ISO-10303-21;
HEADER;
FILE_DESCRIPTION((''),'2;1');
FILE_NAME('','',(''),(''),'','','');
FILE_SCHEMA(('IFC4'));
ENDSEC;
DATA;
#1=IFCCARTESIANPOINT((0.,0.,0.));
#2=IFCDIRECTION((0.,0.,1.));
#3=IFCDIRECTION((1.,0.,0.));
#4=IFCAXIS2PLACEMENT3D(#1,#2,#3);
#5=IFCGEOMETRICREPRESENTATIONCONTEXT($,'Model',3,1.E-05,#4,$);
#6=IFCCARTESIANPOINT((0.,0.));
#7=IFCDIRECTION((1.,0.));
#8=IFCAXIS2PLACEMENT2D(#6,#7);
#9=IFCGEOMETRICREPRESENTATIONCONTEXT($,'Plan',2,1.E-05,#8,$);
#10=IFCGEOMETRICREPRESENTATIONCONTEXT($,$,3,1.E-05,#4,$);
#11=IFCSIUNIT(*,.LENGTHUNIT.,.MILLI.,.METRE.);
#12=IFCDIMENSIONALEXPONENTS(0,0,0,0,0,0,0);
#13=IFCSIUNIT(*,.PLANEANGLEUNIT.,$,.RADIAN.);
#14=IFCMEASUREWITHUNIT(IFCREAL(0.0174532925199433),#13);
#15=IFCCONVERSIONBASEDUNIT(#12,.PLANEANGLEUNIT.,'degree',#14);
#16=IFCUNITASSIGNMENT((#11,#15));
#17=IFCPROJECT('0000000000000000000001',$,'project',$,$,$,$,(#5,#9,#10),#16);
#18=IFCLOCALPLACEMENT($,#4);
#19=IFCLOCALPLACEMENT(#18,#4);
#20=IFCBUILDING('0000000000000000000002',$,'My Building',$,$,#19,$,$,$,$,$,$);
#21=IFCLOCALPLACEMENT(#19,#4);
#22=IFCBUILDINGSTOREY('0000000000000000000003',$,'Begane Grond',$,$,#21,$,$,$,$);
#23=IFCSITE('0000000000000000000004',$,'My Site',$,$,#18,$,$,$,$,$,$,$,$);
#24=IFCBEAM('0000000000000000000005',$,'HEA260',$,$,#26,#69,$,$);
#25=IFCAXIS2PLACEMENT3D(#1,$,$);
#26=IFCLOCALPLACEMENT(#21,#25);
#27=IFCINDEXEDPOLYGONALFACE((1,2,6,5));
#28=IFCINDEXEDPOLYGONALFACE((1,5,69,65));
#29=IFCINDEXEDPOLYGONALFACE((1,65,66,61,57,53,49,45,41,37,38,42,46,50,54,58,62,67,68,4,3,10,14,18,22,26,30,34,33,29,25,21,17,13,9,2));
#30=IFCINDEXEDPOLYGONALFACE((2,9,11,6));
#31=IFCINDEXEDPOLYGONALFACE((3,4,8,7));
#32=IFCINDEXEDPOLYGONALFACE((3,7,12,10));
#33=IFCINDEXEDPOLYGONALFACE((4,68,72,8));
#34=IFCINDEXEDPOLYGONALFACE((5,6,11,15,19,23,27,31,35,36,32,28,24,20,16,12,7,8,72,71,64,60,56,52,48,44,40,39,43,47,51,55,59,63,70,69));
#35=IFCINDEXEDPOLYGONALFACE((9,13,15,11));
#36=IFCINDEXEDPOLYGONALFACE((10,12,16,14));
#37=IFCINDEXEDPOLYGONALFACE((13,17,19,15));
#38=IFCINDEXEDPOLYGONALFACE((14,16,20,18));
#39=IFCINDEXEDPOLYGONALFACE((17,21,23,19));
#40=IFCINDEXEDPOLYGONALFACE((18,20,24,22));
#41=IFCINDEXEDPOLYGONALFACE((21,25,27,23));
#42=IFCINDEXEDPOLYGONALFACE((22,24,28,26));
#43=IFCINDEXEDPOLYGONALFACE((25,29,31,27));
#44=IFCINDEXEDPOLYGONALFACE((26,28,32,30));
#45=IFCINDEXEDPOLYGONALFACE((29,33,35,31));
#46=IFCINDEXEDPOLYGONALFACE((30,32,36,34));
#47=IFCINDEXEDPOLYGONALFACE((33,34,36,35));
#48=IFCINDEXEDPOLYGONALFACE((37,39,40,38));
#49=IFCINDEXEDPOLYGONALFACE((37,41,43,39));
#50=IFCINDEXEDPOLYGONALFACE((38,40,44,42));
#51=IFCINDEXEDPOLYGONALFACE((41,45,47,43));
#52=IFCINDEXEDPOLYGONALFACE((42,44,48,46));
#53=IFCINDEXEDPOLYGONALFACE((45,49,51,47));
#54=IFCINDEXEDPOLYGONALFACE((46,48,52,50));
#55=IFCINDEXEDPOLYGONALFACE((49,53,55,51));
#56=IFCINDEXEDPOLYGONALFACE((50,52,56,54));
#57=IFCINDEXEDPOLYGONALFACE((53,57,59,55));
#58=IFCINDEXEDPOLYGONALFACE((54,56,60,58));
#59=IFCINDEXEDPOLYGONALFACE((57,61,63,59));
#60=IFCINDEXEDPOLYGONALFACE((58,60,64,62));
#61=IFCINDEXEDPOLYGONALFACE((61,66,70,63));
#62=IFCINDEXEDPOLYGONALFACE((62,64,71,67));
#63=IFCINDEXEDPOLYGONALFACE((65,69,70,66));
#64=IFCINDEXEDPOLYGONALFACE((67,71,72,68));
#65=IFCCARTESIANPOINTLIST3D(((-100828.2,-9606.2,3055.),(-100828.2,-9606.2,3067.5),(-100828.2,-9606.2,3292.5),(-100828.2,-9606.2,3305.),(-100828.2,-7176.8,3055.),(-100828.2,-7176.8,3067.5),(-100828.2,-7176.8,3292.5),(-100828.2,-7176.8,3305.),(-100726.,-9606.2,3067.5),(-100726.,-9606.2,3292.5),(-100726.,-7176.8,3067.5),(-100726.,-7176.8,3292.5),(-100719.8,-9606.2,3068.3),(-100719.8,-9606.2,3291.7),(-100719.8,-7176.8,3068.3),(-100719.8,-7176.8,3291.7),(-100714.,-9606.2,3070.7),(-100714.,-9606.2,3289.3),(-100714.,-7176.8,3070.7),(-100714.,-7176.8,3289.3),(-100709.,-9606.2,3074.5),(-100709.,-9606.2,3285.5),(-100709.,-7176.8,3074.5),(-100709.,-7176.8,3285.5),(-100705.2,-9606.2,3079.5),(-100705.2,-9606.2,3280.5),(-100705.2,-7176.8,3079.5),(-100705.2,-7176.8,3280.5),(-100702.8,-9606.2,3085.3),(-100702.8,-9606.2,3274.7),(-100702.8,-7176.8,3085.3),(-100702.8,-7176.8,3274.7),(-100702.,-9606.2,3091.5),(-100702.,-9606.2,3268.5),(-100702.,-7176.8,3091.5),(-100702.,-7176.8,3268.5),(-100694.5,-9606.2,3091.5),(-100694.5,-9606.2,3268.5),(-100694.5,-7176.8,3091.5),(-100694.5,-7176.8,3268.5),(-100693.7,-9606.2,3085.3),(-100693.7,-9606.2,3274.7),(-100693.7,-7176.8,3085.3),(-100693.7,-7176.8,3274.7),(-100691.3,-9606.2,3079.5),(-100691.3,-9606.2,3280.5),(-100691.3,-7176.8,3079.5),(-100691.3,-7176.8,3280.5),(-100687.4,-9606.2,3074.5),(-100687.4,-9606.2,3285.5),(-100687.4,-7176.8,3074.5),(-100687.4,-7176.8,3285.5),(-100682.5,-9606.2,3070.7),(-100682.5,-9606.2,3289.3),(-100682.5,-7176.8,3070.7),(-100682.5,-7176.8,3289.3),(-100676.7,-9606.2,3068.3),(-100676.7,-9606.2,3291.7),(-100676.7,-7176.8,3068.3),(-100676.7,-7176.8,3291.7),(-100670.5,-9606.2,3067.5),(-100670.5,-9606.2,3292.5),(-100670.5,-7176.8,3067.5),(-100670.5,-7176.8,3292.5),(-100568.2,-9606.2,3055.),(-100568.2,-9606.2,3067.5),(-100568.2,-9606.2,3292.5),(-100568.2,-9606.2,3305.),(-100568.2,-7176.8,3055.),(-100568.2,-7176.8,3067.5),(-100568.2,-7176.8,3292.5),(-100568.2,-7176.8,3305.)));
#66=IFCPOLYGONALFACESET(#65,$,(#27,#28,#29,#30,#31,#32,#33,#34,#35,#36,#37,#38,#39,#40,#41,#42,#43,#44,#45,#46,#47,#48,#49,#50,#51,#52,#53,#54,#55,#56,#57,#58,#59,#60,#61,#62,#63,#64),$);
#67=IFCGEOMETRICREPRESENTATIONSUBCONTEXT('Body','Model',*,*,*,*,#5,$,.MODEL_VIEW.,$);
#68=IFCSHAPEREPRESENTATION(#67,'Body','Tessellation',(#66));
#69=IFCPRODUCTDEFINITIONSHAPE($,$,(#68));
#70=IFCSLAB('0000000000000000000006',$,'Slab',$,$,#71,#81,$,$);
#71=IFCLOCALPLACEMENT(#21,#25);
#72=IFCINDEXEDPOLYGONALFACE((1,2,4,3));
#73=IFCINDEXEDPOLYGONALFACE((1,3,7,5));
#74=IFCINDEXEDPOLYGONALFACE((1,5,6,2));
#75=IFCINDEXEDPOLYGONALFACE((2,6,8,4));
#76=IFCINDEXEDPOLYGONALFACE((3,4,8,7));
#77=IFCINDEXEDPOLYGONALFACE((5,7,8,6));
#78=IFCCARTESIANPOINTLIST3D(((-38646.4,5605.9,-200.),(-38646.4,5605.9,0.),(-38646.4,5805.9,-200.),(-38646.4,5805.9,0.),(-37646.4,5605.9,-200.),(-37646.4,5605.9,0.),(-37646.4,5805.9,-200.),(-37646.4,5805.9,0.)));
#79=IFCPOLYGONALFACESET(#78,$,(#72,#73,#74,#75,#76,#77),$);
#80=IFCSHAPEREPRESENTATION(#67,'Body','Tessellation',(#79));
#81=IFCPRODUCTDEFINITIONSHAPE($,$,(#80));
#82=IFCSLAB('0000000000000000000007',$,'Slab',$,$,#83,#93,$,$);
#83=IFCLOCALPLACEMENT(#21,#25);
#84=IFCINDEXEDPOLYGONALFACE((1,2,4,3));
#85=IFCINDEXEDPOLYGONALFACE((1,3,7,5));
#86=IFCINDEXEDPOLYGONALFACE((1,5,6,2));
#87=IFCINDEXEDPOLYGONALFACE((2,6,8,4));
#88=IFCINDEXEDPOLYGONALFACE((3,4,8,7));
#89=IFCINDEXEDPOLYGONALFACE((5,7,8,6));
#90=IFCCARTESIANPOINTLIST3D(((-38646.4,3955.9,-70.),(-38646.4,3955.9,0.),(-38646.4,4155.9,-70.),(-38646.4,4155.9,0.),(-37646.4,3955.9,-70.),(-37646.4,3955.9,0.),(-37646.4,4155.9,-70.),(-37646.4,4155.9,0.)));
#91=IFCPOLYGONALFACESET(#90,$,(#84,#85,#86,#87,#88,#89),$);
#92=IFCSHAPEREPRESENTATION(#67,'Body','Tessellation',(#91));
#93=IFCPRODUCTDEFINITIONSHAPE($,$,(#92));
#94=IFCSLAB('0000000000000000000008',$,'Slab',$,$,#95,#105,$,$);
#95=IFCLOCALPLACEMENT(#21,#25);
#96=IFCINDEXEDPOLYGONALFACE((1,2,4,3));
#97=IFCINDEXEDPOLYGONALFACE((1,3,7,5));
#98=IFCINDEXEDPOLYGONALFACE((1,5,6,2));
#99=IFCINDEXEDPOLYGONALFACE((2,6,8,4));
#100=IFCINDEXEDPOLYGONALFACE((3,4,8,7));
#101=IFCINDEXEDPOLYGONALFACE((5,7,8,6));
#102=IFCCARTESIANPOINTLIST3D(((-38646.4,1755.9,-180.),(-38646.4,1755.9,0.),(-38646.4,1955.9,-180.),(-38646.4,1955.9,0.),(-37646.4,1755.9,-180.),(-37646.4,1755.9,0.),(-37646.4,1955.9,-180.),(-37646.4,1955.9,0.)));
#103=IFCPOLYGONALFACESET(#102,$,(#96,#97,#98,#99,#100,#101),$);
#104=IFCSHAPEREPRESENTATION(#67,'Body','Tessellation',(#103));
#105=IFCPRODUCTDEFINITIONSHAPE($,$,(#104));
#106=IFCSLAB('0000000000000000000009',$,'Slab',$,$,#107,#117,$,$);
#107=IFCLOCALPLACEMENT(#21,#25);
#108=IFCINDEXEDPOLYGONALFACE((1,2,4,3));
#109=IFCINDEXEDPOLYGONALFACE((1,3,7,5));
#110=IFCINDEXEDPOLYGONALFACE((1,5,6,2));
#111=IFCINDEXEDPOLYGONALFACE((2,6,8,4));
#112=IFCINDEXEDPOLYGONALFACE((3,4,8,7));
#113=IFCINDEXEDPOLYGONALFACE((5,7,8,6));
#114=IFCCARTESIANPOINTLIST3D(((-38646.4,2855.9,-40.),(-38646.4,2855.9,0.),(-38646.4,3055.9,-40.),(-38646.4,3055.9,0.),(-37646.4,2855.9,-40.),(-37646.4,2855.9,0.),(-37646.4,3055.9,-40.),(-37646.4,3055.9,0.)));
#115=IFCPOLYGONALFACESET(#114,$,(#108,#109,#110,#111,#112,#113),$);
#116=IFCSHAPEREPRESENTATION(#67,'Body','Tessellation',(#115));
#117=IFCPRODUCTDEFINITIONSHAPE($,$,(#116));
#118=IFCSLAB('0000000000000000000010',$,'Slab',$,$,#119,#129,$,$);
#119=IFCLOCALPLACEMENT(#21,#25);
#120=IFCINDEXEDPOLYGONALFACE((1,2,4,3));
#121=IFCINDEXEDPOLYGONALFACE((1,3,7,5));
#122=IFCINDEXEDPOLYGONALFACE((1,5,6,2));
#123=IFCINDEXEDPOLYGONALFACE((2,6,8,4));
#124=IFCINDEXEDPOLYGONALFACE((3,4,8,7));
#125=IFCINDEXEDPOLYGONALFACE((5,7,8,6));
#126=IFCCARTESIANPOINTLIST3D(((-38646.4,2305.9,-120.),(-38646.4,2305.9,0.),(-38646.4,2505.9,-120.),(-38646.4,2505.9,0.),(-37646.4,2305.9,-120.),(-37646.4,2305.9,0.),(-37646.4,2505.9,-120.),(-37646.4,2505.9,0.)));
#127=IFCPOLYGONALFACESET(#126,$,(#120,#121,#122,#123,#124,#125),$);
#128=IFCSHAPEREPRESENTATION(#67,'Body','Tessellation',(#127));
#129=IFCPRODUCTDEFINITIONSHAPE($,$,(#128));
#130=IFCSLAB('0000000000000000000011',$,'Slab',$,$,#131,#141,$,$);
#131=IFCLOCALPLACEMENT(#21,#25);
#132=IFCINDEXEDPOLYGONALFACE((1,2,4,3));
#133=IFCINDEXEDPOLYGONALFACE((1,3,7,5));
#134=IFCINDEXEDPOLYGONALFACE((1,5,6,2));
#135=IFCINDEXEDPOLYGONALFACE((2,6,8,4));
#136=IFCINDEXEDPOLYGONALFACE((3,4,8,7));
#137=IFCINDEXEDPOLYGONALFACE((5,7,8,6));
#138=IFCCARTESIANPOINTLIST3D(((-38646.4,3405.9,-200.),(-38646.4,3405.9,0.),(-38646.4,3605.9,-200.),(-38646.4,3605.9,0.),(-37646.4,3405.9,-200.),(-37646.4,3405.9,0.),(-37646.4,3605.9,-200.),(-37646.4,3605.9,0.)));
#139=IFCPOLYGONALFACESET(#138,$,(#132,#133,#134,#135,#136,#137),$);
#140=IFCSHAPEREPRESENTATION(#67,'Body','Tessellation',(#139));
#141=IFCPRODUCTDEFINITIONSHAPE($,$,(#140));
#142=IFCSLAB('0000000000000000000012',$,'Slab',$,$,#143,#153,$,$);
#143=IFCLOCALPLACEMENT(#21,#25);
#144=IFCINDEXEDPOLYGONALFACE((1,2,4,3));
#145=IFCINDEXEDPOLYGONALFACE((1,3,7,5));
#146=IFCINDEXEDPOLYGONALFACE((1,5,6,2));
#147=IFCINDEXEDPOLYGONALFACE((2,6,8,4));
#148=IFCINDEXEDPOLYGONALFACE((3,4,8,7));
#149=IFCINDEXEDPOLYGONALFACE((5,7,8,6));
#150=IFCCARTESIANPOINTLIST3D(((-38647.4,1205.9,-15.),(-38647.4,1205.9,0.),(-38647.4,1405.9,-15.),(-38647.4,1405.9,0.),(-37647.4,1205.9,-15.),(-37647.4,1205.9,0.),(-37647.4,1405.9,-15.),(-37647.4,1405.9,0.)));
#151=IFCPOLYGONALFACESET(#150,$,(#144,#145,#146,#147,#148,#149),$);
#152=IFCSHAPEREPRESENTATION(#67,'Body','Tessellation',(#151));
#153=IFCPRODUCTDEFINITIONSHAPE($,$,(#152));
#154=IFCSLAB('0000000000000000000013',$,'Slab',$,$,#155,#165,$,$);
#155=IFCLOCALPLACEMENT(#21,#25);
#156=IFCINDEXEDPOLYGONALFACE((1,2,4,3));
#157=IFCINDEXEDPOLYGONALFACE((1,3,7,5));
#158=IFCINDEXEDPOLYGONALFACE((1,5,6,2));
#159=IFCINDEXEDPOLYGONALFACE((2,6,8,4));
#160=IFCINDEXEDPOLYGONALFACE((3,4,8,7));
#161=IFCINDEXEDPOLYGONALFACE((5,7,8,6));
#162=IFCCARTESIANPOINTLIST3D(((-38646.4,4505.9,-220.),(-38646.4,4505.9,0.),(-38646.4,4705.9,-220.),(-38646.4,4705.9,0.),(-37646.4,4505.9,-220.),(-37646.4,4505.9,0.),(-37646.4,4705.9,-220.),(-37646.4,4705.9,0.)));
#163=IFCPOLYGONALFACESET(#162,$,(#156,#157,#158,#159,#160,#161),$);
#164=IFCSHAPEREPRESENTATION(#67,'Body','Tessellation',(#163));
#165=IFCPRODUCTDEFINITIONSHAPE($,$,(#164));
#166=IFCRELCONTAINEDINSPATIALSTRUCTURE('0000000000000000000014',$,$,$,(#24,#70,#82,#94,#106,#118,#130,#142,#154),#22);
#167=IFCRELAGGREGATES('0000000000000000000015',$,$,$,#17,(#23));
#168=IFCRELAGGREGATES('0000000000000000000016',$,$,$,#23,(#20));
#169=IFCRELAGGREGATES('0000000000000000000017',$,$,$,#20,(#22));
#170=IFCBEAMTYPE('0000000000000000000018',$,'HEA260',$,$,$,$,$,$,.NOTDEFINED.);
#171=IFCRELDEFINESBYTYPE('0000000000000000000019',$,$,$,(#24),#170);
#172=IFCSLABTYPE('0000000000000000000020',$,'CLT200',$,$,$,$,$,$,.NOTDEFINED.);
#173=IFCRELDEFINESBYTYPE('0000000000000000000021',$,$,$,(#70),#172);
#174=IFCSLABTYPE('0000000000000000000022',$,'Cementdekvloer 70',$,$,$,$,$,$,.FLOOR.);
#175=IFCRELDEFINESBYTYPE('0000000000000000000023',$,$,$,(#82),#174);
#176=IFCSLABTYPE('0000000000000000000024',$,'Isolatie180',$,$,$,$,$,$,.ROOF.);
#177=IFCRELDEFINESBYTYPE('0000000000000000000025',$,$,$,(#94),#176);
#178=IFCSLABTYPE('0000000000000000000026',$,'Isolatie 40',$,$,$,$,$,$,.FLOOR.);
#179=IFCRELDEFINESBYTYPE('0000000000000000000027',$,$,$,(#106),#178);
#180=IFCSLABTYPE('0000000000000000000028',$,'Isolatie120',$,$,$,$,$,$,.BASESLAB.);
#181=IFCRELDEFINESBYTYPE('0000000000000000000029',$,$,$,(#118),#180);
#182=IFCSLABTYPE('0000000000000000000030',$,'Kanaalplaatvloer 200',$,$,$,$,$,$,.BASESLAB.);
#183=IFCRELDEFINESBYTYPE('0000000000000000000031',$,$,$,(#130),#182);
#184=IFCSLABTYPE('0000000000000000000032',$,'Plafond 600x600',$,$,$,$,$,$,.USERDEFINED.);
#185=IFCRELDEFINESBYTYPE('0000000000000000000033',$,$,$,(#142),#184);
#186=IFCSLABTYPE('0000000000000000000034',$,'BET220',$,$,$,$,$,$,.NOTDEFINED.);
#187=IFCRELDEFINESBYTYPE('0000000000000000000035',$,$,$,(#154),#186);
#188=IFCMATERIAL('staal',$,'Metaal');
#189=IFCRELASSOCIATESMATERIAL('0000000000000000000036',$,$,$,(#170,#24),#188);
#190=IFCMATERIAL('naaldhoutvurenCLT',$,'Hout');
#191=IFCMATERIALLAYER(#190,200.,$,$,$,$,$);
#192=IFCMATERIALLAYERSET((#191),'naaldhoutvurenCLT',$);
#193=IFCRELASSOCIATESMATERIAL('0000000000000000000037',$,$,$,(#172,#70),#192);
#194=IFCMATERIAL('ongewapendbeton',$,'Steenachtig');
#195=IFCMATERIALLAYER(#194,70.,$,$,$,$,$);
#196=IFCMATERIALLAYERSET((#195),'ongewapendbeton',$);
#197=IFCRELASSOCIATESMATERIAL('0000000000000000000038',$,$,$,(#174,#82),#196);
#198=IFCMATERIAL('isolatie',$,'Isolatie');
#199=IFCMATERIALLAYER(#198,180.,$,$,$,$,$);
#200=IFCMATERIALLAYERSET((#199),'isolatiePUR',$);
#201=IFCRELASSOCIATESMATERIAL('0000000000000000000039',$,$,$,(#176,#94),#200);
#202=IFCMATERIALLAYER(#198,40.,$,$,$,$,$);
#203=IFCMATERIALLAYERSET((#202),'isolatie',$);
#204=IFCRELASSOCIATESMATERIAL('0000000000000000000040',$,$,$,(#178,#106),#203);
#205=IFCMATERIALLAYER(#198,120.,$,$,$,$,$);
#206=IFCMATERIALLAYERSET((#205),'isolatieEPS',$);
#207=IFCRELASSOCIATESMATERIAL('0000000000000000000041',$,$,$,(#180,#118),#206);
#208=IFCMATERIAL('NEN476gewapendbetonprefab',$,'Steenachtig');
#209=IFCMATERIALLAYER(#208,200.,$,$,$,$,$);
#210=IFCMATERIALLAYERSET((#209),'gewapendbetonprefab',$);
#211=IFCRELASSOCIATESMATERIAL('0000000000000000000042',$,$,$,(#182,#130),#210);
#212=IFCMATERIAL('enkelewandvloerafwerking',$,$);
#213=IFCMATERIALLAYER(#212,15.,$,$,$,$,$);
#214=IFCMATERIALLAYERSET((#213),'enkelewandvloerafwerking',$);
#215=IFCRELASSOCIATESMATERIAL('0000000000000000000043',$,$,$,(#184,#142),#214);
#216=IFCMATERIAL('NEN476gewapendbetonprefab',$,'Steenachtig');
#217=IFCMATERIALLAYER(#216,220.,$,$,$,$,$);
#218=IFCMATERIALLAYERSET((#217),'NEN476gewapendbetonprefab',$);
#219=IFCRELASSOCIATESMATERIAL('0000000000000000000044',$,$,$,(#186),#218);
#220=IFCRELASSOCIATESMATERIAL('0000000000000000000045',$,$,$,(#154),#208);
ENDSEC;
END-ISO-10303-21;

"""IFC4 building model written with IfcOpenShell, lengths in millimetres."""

from ifc_helpers import new_model, entity, si_unit, converted_unit, frame, origin_with_axes, origin_2d_with_axis, place, context, subcontext, project, spatial, line, indexed_curve, i_section, outline, extrude, material, layer, layer_set, layer_usage, material_profile, profile_set, profile_usage, type_object, element, save


model = new_model("IFC4")

# Units and contexts
model_context = context("Model", 3, precision=1e-05, world=origin_with_axes())
plan_context = context("Plan", 2, precision=1e-05, world=origin_2d_with_axis())
context_of_model = context(None, 3, precision=1e-05, world=origin_with_axes())
body_context = subcontext(model_context, "Body", "Model", "MODEL_VIEW")
ifc_project = project(units=[si_unit("LENGTHUNIT", "METRE", prefix="MILLI"), converted_unit("PLANEANGLEUNIT", "degree", entity("IfcReal", 0.0174532925199433), si_unit("PLANEANGLEUNIT", "RADIAN"), dimensions=[0, 0, 0, 0, 0, 0, 0])], contexts=[model_context, plan_context, context_of_model])

# Site, building, storey
site_placement = place(None, frame((0.0, 0.0, 0.0), z_axis=(0.0, 0.0, 1.0), x_axis=(1.0, 0.0, 0.0)))
site = spatial("IfcSite", under=ifc_project, at=site_placement, Name="My Site")
building_placement = place(site_placement, origin_with_axes())
building = spatial("IfcBuilding", under=site, at=building_placement, Name="My Building")
storey_placement = place(building_placement, origin_with_axes())
storey = spatial("IfcBuildingStorey", under=building, at=storey_placement, Name="Begane Grond")

# Beam
ifc_material_1 = material(Name="staal", Category="Metaal")
ifc_material_profile = material_profile(ifc_material_1, i_section(OverallWidth=260.0, OverallDepth=250.0, WebThickness=7.5, FlangeThickness=12.5, FilletRadius=24.0))
ifc_profile_set = profile_set([ifc_material_profile], Name="HEA260")
ifc_profile_usage = profile_usage(ifc_profile_set, cardinal=5)
beam_type = type_object("IfcBeamType", Name="HEA260", PredefinedType="NOTDEFINED", material=ifc_profile_set)
beam_placement = place(storey_placement, frame((-100698.2, -9606.2, 3180.0), z_axis=(0.0, 1.0, 0.0), x_axis=(-1.0, 0.0, 0.0)))
element("IfcBeam", 1, at=beam_placement, inside=storey, type_object=beam_type, material=ifc_profile_usage, Name="HEA260", context=body_context, shape_type="SweptSolid", body=[
    extrude(i_section(OverallWidth=260.0, OverallDepth=250.0, WebThickness=7.5, FlangeThickness=12.5, FilletRadius=24.0), origin_with_axes(), (0.0, 0.0, 1.0), 2429.4),
])

# Slabs
ifc_material_2 = material(Name="naaldhoutvurenCLT", Category="Hout")
ifc_layer_1 = layer(ifc_material_2, 200.0)
ifc_layer_set_1 = layer_set([ifc_layer_1], Name="naaldhoutvurenCLT")
ifc_layer_usage_1 = layer_usage(ifc_layer_set_1, "AXIS3", "POSITIVE", 0.0)
slab_type_1 = type_object("IfcSlabType", Name="CLT200", PredefinedType="NOTDEFINED", material=ifc_layer_set_1)
slab_1_placement = place(storey_placement, frame((-38646.4, 5605.9, -200.0), z_axis=(0.0, 0.0, 1.0), x_axis=(1.0, 0.0, 0.0)))
element("IfcSlab", 2, at=slab_1_placement, inside=storey, type_object=slab_type_1, material=ifc_layer_usage_1, Name="Slab", context=body_context, shape_type="SweptSolid", body=[
    extrude(outline(indexed_curve([(1000.0, 200.0), (1000.0, 0.0), (0.0, 0.0), (0.0, 200.0)], segments=[line(3, 2), line(2, 1), line(1, 4), line(4, 3)], self_intersect=False)), None, (0.0, 0.0, 1.0), 200.0),
])
ifc_material_3 = material(Name="ongewapendbeton", Category="Steenachtig")
ifc_layer_2 = layer(ifc_material_3, 70.0)
ifc_layer_set_2 = layer_set([ifc_layer_2], Name="ongewapendbeton")
ifc_layer_usage_2 = layer_usage(ifc_layer_set_2, "AXIS3", "POSITIVE", 0.0)
slab_type_2 = type_object("IfcSlabType", Name="Cementdekvloer 70", PredefinedType="FLOOR", material=ifc_layer_set_2)
slab_2_placement = place(storey_placement, frame((-38646.4, 3955.9, -70.0), z_axis=(0.0, 0.0, 1.0), x_axis=(1.0, 0.0, 0.0)))
element("IfcSlab", 3, at=slab_2_placement, inside=storey, type_object=slab_type_2, material=ifc_layer_usage_2, Name="Slab", context=body_context, shape_type="SweptSolid", body=[
    extrude(outline(indexed_curve([(1000.0, 200.0), (1000.0, 0.0), (0.0, 0.0), (0.0, 200.0)], segments=[line(4, 1), line(1, 2), line(2, 3), line(3, 4)], self_intersect=False)), None, (0.0, 0.0, 1.0), 70.0),
])
ifc_material_4 = material(Name="isolatie", Category="Isolatie")
ifc_layer_3 = layer(ifc_material_4, 180.0)
ifc_layer_set_3 = layer_set([ifc_layer_3], Name="isolatiePUR")
ifc_layer_usage_3 = layer_usage(ifc_layer_set_3, "AXIS3", "POSITIVE", 0.0)
slab_type_3 = type_object("IfcSlabType", Name="Isolatie180", PredefinedType="ROOF", material=ifc_layer_set_3)
slab_3_placement = place(storey_placement, frame((-38646.4, 1755.9, -180.0), z_axis=(0.0, 0.0, 1.0), x_axis=(1.0, 0.0, 0.0)))
element("IfcSlab", 4, at=slab_3_placement, inside=storey, type_object=slab_type_3, material=ifc_layer_usage_3, Name="Slab", context=body_context, shape_type="SweptSolid", body=[
    extrude(outline(indexed_curve([(1000.0, 200.0), (1000.0, 0.0), (0.0, 0.0), (0.0, 200.0)], segments=[line(4, 1), line(1, 2), line(2, 3), line(3, 4)], self_intersect=False)), None, (0.0, 0.0, 1.0), 180.0),
])
ifc_layer_4 = layer(ifc_material_4, 40.0)
ifc_layer_set_4 = layer_set([ifc_layer_4], Name="isolatie")
ifc_layer_usage_4 = layer_usage(ifc_layer_set_4, "AXIS3", "POSITIVE", 0.0)
slab_type_4 = type_object("IfcSlabType", Name="Isolatie 40", PredefinedType="FLOOR", material=ifc_layer_set_4)
slab_4_placement = place(storey_placement, frame((-38646.4, 2855.9, -40.0), z_axis=(0.0, 0.0, 1.0), x_axis=(1.0, 0.0, 0.0)))
element("IfcSlab", 5, at=slab_4_placement, inside=storey, type_object=slab_type_4, material=ifc_layer_usage_4, Name="Slab", context=body_context, shape_type="SweptSolid", body=[
    extrude(outline(indexed_curve([(1000.0, 200.0), (1000.0, 0.0), (0.0, 0.0), (0.0, 200.0)], segments=[line(3, 2), line(2, 1), line(1, 4), line(4, 3)], self_intersect=False)), None, (0.0, 0.0, 1.0), 40.0),
])
ifc_layer_5 = layer(ifc_material_4, 120.0)
ifc_layer_set_5 = layer_set([ifc_layer_5], Name="isolatieEPS")
ifc_layer_usage_5 = layer_usage(ifc_layer_set_5, "AXIS3", "POSITIVE", 0.0)
slab_type_5 = type_object("IfcSlabType", Name="Isolatie120", PredefinedType="BASESLAB", material=ifc_layer_set_5)
slab_5_placement = place(storey_placement, frame((-38646.4, 2305.9, -120.0), z_axis=(0.0, 0.0, 1.0), x_axis=(1.0, 0.0, 0.0)))
element("IfcSlab", 6, at=slab_5_placement, inside=storey, type_object=slab_type_5, material=ifc_layer_usage_5, Name="Slab", context=body_context, shape_type="SweptSolid", body=[
    extrude(outline(indexed_curve([(1000.0, 200.0), (1000.0, 0.0), (0.0, 0.0), (0.0, 200.0)], segments=[line(3, 2), line(2, 1), line(1, 4), line(4, 3)], self_intersect=False)), None, (0.0, 0.0, 1.0), 120.0),
])
ifc_material_5 = material(Name="NEN476gewapendbetonprefab", Category="Steenachtig")
ifc_layer_6 = layer(ifc_material_5, 200.0)
ifc_layer_set_6 = layer_set([ifc_layer_6], Name="gewapendbetonprefab")
ifc_layer_usage_6 = layer_usage(ifc_layer_set_6, "AXIS3", "POSITIVE", 0.0)
slab_type_6 = type_object("IfcSlabType", Name="Kanaalplaatvloer 200", PredefinedType="BASESLAB", material=ifc_layer_set_6)
slab_6_placement = place(storey_placement, frame((-38646.4, 3405.9, -200.0), z_axis=(0.0, 0.0, 1.0), x_axis=(1.0, 0.0, 0.0)))
element("IfcSlab", 7, at=slab_6_placement, inside=storey, type_object=slab_type_6, material=ifc_layer_usage_6, Name="Slab", context=body_context, shape_type="SweptSolid", body=[
    extrude(outline(indexed_curve([(1000.0, 200.0), (1000.0, 0.0), (0.0, 0.0), (0.0, 200.0)], segments=[line(4, 1), line(1, 2), line(2, 3), line(3, 4)], self_intersect=False)), None, (0.0, 0.0, 1.0), 200.0),
])
ifc_material_6 = material(Name="enkelewandvloerafwerking")
ifc_layer_7 = layer(ifc_material_6, 15.0)
ifc_layer_set_7 = layer_set([ifc_layer_7], Name="enkelewandvloerafwerking")
ifc_layer_usage_7 = layer_usage(ifc_layer_set_7, "AXIS3", "POSITIVE", 0.0)
slab_type_7 = type_object("IfcSlabType", Name="Plafond 600x600", PredefinedType="USERDEFINED", material=ifc_layer_set_7)
slab_7_placement = place(storey_placement, frame((-38647.4, 1205.9, -15.0), z_axis=(0.0, 0.0, 1.0), x_axis=(1.0, 0.0, 0.0)))
element("IfcSlab", 8, at=slab_7_placement, inside=storey, type_object=slab_type_7, material=ifc_layer_usage_7, Name="Slab", context=body_context, shape_type="SweptSolid", body=[
    extrude(outline(indexed_curve([(1000.0, 200.0), (1000.0, 0.0), (0.0, 0.0), (0.0, 200.0)], segments=[line(4, 1), line(1, 2), line(2, 3), line(3, 4)], self_intersect=False)), None, (0.0, 0.0, 1.0), 15.0),
])
ifc_material_7 = material(Name="NEN476gewapendbetonprefab", Category="Steenachtig")
ifc_layer_8 = layer(ifc_material_7, 220.0)
ifc_layer_set_8 = layer_set([ifc_layer_8], Name="NEN476gewapendbetonprefab")
slab_type_8 = type_object("IfcSlabType", Name="BET220", PredefinedType="NOTDEFINED", material=ifc_layer_set_8)
slab_8_placement = place(storey_placement, frame((-38646.4, 4505.9, -220.0), z_axis=(0.0, 0.0, 1.0), x_axis=(1.0, 0.0, 0.0)))
element("IfcSlab", 9, at=slab_8_placement, inside=storey, type_object=slab_type_8, material=ifc_material_5, Name="Slab", context=body_context, shape_type="SweptSolid", body=[
    extrude(outline(indexed_curve([(1000.0, 200.0), (1000.0, 0.0), (0.0, 0.0), (0.0, 200.0)], segments=[line(4, 1), line(1, 2), line(2, 3), line(3, 4)], self_intersect=False)), None, (0.0, 0.0, 1.0), 220.0),
])

save(model, "model.ifc")
